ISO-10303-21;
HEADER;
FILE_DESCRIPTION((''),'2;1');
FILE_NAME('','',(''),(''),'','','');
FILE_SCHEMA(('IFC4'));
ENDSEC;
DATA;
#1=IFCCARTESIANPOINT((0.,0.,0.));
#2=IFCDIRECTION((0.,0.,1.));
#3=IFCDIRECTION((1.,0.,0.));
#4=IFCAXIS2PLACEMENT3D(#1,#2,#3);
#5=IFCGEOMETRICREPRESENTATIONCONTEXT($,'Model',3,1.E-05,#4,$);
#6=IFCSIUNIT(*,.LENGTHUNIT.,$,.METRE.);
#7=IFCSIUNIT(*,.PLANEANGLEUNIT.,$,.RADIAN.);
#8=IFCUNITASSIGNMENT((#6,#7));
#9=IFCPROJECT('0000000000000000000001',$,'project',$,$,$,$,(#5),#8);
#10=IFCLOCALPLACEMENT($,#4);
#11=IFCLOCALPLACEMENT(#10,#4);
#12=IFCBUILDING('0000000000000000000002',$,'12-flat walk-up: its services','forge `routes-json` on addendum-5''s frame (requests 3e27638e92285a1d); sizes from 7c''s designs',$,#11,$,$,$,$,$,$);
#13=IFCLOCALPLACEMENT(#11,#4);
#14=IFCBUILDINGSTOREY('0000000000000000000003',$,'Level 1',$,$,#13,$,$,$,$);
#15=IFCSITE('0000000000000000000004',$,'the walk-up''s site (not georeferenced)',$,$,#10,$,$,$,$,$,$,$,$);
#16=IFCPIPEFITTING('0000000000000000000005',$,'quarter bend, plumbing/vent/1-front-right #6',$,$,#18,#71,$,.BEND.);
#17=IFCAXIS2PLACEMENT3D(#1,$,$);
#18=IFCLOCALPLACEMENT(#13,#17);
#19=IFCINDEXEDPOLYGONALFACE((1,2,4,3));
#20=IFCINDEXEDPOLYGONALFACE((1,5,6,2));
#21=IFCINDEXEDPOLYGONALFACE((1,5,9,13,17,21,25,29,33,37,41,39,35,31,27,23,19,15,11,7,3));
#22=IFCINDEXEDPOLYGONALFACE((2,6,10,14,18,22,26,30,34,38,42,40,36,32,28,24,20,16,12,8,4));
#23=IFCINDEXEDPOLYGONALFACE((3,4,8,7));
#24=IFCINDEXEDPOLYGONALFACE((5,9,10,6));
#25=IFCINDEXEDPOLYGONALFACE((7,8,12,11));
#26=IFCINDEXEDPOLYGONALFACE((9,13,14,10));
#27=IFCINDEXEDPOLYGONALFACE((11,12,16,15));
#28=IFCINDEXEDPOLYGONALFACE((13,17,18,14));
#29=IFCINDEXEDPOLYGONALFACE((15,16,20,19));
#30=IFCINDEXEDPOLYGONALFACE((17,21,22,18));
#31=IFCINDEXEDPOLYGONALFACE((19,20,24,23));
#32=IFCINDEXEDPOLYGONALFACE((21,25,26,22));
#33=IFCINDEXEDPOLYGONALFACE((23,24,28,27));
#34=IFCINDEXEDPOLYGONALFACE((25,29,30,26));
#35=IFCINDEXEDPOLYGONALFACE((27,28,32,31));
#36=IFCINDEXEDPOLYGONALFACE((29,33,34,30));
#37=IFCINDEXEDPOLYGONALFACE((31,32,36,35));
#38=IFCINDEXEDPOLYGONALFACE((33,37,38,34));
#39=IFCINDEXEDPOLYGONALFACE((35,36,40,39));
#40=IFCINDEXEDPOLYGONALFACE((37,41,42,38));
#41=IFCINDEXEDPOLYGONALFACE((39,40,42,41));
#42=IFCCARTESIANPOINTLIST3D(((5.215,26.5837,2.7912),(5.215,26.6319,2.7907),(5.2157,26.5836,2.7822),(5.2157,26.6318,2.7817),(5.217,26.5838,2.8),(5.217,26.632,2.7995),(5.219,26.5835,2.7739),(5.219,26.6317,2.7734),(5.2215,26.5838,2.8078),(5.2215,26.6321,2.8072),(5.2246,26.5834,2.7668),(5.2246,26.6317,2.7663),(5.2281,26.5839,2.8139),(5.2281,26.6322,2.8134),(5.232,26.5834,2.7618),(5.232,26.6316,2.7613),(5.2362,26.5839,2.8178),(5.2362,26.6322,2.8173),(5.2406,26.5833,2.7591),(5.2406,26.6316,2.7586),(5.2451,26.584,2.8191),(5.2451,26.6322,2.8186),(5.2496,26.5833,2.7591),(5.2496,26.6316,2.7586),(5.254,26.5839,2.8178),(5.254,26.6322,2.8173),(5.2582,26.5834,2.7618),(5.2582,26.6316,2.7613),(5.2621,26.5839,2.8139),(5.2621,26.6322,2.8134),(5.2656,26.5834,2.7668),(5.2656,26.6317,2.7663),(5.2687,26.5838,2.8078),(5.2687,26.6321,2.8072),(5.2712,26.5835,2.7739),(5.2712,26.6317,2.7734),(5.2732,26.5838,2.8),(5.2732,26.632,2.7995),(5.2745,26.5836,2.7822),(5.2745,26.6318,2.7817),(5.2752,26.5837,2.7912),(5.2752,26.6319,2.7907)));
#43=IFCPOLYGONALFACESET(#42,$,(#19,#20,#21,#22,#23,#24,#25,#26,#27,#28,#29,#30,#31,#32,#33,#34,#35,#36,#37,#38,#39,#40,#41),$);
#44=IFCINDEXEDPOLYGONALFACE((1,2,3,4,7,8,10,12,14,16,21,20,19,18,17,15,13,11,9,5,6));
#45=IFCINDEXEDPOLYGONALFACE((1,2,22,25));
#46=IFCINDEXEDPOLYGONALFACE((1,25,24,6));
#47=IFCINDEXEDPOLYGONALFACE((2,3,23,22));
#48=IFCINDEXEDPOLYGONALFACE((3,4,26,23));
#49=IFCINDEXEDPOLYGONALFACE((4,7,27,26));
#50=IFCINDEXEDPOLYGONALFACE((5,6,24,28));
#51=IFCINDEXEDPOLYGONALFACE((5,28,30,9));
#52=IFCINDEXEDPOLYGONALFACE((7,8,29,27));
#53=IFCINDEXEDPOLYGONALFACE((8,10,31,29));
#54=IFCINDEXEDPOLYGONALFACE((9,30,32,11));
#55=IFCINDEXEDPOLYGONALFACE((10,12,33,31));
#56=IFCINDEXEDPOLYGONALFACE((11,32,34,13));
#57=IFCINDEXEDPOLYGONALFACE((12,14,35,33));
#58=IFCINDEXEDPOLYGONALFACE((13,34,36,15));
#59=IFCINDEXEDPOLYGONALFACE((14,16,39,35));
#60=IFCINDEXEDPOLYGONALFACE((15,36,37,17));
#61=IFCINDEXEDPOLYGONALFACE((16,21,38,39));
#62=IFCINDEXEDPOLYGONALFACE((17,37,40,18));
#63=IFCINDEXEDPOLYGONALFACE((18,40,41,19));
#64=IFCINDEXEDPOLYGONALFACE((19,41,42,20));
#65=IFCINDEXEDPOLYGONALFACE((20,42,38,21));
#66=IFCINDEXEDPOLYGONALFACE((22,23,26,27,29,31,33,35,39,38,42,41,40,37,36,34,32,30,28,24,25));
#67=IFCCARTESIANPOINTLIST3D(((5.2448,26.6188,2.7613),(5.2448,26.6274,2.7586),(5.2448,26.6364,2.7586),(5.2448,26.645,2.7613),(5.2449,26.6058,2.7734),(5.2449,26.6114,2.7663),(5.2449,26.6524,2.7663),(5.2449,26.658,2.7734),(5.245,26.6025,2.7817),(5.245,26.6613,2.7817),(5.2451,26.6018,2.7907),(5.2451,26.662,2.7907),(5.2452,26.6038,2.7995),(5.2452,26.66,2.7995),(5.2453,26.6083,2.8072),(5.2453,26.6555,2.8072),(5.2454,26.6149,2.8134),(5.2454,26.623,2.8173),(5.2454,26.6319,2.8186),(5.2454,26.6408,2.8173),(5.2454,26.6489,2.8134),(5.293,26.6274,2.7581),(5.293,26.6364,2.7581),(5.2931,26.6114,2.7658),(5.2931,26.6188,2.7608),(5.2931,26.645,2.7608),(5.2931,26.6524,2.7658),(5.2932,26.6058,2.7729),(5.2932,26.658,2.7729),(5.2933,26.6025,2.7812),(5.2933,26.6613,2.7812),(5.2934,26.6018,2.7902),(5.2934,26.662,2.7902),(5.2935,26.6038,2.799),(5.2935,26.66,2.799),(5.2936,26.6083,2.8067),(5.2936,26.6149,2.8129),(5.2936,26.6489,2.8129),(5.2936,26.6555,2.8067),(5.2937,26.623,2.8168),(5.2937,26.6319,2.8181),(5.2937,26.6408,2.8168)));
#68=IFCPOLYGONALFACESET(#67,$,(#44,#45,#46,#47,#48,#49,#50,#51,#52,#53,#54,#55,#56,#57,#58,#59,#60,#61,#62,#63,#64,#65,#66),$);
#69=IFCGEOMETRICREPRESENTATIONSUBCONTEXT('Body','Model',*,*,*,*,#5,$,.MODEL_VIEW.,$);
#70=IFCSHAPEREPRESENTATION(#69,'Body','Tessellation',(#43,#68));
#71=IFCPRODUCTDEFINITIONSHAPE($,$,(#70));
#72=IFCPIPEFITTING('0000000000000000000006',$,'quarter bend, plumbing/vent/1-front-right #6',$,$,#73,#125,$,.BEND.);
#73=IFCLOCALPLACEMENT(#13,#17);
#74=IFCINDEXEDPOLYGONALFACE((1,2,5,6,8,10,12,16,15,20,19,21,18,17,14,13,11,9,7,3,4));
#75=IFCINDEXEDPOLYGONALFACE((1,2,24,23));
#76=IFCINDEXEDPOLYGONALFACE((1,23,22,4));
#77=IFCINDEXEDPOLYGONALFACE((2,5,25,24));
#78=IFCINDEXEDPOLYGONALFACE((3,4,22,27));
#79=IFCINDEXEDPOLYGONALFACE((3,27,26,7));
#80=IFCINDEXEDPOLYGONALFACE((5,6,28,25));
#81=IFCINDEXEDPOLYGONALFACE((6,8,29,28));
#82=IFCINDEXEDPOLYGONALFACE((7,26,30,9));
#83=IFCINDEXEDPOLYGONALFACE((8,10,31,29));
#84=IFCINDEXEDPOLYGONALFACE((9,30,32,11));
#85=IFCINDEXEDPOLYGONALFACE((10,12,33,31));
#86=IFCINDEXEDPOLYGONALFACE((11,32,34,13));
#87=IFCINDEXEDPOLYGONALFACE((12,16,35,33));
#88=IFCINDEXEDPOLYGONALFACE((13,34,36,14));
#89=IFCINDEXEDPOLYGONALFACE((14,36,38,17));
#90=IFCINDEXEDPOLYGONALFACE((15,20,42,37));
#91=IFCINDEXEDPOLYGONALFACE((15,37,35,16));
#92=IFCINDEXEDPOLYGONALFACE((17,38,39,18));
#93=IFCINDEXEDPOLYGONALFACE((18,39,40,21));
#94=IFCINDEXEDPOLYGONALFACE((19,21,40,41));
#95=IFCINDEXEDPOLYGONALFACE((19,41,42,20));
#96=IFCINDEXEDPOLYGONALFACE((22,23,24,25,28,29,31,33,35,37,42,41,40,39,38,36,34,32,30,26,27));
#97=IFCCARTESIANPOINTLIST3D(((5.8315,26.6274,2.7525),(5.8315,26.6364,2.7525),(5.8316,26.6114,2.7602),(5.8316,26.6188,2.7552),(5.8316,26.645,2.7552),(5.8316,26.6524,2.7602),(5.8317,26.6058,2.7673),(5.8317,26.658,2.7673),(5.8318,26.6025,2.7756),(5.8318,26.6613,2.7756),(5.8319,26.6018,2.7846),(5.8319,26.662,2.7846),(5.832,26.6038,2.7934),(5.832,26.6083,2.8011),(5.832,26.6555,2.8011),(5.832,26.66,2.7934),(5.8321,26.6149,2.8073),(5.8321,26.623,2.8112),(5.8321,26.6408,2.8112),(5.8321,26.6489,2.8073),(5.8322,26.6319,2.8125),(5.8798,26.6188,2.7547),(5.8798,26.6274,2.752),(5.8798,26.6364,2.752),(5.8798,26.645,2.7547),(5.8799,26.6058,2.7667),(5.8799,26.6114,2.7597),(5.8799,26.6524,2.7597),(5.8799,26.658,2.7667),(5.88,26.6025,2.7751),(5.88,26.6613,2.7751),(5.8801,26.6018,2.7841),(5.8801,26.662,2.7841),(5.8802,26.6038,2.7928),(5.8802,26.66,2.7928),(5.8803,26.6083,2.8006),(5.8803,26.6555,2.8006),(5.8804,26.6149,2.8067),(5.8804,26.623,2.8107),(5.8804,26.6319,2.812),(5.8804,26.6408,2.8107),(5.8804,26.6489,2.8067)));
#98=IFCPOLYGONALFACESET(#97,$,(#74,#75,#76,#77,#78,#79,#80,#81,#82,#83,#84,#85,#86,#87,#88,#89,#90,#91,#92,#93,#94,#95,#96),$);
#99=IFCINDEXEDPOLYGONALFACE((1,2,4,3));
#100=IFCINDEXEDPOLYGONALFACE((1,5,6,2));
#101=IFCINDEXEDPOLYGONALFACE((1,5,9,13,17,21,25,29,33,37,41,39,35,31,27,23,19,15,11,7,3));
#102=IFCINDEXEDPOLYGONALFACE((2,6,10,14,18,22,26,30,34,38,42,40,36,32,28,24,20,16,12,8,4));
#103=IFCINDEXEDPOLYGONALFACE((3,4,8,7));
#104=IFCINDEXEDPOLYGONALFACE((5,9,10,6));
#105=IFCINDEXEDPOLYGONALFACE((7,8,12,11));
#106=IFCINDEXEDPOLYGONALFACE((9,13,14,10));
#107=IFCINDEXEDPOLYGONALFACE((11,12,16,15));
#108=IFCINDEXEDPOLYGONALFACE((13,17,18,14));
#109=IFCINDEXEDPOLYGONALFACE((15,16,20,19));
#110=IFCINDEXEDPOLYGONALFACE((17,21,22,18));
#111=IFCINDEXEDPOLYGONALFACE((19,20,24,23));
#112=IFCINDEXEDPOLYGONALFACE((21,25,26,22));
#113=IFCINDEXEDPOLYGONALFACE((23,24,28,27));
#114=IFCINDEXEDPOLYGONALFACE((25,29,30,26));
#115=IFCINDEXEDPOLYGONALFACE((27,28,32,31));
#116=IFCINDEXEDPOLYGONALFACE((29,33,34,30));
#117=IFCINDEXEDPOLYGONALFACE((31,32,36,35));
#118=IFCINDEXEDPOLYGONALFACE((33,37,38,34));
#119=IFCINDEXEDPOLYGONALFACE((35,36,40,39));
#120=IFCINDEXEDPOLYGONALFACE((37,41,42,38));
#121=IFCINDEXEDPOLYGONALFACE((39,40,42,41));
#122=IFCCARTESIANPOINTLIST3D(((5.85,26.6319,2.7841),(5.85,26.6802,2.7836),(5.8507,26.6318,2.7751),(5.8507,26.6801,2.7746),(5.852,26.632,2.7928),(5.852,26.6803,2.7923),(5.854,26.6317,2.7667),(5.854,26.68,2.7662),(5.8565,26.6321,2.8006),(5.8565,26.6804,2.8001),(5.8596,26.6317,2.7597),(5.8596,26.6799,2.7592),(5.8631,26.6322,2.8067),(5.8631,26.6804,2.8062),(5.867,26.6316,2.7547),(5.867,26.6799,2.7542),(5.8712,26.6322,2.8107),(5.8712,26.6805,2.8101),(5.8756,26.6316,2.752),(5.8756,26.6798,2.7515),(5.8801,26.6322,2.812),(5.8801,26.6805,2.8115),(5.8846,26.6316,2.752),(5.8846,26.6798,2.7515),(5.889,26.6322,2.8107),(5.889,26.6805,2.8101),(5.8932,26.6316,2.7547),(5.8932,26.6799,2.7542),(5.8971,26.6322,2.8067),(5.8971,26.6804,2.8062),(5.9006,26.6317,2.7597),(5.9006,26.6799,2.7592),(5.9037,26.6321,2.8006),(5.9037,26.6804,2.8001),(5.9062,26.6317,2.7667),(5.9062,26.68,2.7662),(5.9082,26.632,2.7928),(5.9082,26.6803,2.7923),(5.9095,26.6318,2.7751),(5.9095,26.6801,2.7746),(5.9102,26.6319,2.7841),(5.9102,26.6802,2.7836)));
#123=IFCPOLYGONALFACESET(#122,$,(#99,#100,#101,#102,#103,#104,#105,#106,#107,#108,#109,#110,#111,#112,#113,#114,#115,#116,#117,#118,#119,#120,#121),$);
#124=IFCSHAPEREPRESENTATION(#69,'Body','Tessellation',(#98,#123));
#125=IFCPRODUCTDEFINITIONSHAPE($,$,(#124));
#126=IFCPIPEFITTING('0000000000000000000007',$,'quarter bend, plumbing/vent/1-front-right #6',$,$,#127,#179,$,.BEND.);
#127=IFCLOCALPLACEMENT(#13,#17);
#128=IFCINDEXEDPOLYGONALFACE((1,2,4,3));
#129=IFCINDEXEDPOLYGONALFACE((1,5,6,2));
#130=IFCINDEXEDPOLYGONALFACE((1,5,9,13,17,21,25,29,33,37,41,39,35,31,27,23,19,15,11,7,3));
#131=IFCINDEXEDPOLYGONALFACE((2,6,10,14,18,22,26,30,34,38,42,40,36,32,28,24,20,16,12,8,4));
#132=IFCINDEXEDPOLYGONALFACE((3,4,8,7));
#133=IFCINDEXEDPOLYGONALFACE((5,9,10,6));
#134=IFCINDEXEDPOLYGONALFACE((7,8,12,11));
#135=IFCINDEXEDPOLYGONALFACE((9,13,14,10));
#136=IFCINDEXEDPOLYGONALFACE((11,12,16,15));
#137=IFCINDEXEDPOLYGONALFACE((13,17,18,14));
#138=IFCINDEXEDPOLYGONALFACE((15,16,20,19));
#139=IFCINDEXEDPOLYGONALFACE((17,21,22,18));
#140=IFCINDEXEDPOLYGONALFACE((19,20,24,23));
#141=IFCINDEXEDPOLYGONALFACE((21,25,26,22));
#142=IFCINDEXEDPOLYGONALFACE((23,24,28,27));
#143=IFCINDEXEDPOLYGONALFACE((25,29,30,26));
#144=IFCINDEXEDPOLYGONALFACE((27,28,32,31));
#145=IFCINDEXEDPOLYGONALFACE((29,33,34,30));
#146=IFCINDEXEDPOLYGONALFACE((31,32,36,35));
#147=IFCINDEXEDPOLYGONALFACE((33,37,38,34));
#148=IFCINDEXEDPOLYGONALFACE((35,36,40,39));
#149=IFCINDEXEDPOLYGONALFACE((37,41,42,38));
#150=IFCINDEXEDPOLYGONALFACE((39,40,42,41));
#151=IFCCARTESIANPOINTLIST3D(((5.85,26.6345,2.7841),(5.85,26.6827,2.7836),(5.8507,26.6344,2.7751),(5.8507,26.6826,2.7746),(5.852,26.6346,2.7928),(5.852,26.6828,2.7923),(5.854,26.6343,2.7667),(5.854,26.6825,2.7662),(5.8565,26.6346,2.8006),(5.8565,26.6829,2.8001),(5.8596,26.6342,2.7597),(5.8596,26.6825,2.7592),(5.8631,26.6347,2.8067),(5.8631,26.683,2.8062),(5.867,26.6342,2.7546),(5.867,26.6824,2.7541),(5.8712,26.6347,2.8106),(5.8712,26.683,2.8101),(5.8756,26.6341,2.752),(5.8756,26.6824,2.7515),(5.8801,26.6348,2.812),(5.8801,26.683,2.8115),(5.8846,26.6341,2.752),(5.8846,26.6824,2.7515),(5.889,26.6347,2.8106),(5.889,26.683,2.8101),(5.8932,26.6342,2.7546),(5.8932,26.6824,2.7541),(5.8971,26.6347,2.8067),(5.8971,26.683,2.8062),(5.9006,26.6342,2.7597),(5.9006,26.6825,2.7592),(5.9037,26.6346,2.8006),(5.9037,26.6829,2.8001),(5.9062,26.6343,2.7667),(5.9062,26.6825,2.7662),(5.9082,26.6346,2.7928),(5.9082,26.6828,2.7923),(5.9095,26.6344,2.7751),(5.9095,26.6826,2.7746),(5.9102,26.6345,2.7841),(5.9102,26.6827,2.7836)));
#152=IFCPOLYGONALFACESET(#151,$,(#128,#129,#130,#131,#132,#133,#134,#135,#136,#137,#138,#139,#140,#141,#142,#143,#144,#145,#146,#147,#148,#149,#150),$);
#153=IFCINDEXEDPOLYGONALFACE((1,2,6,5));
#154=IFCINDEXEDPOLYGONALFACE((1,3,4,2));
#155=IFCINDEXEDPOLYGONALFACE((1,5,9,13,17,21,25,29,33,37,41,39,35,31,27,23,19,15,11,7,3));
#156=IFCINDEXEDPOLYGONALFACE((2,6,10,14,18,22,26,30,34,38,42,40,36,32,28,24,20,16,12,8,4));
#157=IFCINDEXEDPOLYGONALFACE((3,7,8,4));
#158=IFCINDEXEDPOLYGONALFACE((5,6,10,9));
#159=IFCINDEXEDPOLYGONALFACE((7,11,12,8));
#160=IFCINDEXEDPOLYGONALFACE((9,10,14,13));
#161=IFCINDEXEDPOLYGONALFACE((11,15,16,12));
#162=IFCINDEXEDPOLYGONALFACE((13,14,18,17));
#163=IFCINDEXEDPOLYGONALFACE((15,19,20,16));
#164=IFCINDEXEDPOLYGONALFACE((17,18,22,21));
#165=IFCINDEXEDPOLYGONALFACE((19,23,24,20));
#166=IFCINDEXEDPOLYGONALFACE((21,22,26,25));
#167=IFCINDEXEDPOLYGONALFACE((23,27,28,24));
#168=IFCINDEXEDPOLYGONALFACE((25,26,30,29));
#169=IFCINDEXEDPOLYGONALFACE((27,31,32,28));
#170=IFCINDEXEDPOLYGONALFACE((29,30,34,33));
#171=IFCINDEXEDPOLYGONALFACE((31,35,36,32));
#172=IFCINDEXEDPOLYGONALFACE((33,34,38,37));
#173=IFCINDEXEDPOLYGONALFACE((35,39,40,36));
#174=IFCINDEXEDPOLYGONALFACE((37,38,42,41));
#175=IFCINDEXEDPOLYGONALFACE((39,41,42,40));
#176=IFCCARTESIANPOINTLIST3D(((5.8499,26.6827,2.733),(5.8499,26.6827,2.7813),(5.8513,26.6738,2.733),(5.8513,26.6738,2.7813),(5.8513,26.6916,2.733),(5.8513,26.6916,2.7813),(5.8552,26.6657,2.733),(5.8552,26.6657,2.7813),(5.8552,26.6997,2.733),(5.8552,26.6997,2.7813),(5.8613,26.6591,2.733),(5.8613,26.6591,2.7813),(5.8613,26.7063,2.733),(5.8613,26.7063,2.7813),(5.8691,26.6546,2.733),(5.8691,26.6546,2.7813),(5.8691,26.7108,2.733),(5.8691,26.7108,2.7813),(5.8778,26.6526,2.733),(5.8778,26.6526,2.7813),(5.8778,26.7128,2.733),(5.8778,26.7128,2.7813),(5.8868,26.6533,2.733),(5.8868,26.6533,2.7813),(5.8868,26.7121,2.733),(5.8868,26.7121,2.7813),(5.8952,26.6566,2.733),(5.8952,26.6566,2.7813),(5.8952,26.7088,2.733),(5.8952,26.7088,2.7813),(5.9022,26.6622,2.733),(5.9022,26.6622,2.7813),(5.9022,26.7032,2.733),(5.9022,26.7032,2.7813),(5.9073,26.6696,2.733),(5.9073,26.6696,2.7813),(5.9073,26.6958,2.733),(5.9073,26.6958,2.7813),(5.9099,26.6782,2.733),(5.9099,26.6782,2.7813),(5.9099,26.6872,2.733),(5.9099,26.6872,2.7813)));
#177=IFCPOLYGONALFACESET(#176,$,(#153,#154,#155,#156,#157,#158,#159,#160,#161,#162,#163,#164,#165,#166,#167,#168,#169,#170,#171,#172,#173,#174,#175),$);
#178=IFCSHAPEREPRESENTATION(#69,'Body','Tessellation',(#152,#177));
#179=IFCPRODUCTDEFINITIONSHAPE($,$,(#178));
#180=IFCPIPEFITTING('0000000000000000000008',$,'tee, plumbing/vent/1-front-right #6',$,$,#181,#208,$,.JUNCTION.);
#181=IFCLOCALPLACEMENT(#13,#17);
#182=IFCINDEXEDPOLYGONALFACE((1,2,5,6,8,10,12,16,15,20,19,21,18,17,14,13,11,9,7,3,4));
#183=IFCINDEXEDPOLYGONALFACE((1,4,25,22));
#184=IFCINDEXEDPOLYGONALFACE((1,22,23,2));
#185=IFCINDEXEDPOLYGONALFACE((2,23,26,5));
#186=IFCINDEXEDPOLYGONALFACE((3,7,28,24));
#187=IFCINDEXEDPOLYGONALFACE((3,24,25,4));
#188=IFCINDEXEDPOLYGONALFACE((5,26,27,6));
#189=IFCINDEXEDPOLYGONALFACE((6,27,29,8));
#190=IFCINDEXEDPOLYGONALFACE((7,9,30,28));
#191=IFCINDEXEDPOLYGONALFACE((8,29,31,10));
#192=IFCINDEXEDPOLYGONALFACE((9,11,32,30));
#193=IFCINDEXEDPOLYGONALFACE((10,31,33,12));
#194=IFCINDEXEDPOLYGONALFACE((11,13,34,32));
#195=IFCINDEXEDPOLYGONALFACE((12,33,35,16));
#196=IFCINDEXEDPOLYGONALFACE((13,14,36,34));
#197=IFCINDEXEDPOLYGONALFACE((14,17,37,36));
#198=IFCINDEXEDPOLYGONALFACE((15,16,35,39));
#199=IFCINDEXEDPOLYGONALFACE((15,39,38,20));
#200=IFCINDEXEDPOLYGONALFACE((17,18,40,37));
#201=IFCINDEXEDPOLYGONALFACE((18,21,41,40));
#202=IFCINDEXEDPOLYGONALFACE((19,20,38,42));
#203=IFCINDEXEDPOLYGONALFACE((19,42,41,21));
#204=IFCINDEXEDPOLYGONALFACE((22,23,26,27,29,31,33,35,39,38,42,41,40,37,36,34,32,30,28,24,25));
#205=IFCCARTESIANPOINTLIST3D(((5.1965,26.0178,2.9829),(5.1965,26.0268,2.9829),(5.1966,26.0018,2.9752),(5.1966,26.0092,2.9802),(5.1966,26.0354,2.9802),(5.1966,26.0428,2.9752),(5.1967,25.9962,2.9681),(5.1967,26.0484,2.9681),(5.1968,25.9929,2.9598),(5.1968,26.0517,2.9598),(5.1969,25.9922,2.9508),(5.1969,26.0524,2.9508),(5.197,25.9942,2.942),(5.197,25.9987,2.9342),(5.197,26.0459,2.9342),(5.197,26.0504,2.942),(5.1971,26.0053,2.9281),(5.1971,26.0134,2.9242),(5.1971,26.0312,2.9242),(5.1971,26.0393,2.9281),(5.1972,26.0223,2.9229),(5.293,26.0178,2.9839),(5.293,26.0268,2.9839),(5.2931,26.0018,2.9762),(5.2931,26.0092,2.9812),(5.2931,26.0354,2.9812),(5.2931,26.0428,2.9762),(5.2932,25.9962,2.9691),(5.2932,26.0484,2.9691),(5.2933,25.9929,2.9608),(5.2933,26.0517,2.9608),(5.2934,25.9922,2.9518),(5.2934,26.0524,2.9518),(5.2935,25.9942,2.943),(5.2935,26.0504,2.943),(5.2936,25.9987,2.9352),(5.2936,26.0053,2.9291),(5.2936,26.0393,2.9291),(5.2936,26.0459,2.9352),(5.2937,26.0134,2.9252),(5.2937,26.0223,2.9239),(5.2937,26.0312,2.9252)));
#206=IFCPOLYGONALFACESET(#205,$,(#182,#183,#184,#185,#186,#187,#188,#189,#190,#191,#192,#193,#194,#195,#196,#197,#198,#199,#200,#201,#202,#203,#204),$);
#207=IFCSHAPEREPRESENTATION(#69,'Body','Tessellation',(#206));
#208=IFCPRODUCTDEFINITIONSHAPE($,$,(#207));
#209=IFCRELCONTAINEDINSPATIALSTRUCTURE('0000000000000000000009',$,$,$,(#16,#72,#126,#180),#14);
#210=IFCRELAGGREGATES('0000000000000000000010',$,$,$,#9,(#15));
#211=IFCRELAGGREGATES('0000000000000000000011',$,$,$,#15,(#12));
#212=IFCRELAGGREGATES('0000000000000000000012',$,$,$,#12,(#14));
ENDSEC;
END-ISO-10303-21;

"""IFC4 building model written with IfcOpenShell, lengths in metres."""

from ifc_helpers import new_model, entity, si_unit, frame, origin_with_axes, place, context, subcontext, project, spatial, element, save


model = new_model("IFC4")

# Units and contexts
model_context = context("Model", 3, precision=1e-05, world=origin_with_axes())
body_context = subcontext(model_context, "Body", "Model", "MODEL_VIEW")
ifc_project = project(units=[si_unit("LENGTHUNIT", "METRE"), si_unit("PLANEANGLEUNIT", "RADIAN")], contexts=[model_context])

# Site, building, storey
site_placement = place(None, origin_with_axes())
site = spatial("IfcSite", under=ifc_project, at=site_placement, Name="the walk-up's site (not georeferenced)")
building_placement = place(site_placement, origin_with_axes())
building = spatial("IfcBuilding", under=site, at=building_placement, Name="12-flat walk-up: its services", Description="forge `routes-json` on addendum-5's frame (requests 3e27638e92285a1d); sizes from 7c's designs")
storey_placement = place(building_placement, origin_with_axes())
storey = spatial("IfcBuildingStorey", under=building, at=storey_placement, Name="Level 1")

# Pipe fittings
pipe_fitting_1_placement = place(storey_placement, frame((5.2451, 26.5836, 2.7889), z_axis=(0.0, 0.0, 1.0), x_axis=(1.0, 0.0, 0.0)))
element("IfcPipeFitting", 1, at=pipe_fitting_1_placement, inside=storey, Name="quarter bend, plumbing/vent/1-front-right #6", PredefinedType="BEND", context=body_context, shape_type="AdvancedSweptSolid", body=[
    entity("IfcSweptDiskSolid", entity("IfcPolyline", [entity("IfcCartesianPoint", [0.0, 0.0, 0.0]), entity("IfcCartesianPoint", [0.0, 0.0483, -0.0005])]), 0.0302),
    entity("IfcSweptDiskSolid", entity("IfcPolyline", [entity("IfcCartesianPoint", [0.0, 0.0483, -0.0005]), entity("IfcCartesianPoint", [0.0483, 0.0483, -0.001])]), 0.0302),
])
pipe_fitting_2_placement = place(storey_placement, frame((5.8318, 26.6319, 2.7823), z_axis=(0.0, 0.0, 1.0), x_axis=(1.0, 0.0, 0.0)))
element("IfcPipeFitting", 2, at=pipe_fitting_2_placement, inside=storey, Name="quarter bend, plumbing/vent/1-front-right #6", PredefinedType="BEND", context=body_context, shape_type="AdvancedSweptSolid", body=[
    entity("IfcSweptDiskSolid", entity("IfcPolyline", [entity("IfcCartesianPoint", [0.0, 0.0, 0.0]), entity("IfcCartesianPoint", [0.0483, 0.0, -0.0005])]), 0.0302),
    entity("IfcSweptDiskSolid", entity("IfcPolyline", [entity("IfcCartesianPoint", [0.0483, 0.0, -0.0005]), entity("IfcCartesianPoint", [0.0483, 0.0483, -0.001])]), 0.0302),
])
pipe_fitting_3_placement = place(storey_placement, frame((5.8801, 26.6344, 2.7818), z_axis=(0.0, 0.0, 1.0), x_axis=(1.0, 0.0, 0.0)))
element("IfcPipeFitting", 3, at=pipe_fitting_3_placement, inside=storey, Name="quarter bend, plumbing/vent/1-front-right #6", PredefinedType="BEND", context=body_context, shape_type="AdvancedSweptSolid", body=[
    entity("IfcSweptDiskSolid", entity("IfcPolyline", [entity("IfcCartesianPoint", [0.0, 0.0, 0.0]), entity("IfcCartesianPoint", [0.0, 0.0483, -0.0005])]), 0.0302),
    entity("IfcSweptDiskSolid", entity("IfcPolyline", [entity("IfcCartesianPoint", [0.0, 0.0483, -0.0005]), entity("IfcCartesianPoint", [0.0, 0.0483, -0.0488])]), 0.0302),
])
pipe_fitting_4_placement = place(storey_placement, frame((5.2934, 26.0223, 2.954), z_axis=(0.0, 0.0, 1.0), x_axis=(1.0, 0.0, 0.0)))
element("IfcPipeFitting", 4, at=pipe_fitting_4_placement, inside=storey, Name="tee, plumbing/vent/1-front-right #6", PredefinedType="JUNCTION", context=body_context, shape_type="AdvancedSweptSolid", body=[
    entity("IfcSweptDiskSolid", entity("IfcPolyline", [entity("IfcCartesianPoint", [0.0, 0.0, 0.0]), entity("IfcCartesianPoint", [-0.0965, 0.0, -0.001])]), 0.0302),
])

save(model, "model.ifc")
